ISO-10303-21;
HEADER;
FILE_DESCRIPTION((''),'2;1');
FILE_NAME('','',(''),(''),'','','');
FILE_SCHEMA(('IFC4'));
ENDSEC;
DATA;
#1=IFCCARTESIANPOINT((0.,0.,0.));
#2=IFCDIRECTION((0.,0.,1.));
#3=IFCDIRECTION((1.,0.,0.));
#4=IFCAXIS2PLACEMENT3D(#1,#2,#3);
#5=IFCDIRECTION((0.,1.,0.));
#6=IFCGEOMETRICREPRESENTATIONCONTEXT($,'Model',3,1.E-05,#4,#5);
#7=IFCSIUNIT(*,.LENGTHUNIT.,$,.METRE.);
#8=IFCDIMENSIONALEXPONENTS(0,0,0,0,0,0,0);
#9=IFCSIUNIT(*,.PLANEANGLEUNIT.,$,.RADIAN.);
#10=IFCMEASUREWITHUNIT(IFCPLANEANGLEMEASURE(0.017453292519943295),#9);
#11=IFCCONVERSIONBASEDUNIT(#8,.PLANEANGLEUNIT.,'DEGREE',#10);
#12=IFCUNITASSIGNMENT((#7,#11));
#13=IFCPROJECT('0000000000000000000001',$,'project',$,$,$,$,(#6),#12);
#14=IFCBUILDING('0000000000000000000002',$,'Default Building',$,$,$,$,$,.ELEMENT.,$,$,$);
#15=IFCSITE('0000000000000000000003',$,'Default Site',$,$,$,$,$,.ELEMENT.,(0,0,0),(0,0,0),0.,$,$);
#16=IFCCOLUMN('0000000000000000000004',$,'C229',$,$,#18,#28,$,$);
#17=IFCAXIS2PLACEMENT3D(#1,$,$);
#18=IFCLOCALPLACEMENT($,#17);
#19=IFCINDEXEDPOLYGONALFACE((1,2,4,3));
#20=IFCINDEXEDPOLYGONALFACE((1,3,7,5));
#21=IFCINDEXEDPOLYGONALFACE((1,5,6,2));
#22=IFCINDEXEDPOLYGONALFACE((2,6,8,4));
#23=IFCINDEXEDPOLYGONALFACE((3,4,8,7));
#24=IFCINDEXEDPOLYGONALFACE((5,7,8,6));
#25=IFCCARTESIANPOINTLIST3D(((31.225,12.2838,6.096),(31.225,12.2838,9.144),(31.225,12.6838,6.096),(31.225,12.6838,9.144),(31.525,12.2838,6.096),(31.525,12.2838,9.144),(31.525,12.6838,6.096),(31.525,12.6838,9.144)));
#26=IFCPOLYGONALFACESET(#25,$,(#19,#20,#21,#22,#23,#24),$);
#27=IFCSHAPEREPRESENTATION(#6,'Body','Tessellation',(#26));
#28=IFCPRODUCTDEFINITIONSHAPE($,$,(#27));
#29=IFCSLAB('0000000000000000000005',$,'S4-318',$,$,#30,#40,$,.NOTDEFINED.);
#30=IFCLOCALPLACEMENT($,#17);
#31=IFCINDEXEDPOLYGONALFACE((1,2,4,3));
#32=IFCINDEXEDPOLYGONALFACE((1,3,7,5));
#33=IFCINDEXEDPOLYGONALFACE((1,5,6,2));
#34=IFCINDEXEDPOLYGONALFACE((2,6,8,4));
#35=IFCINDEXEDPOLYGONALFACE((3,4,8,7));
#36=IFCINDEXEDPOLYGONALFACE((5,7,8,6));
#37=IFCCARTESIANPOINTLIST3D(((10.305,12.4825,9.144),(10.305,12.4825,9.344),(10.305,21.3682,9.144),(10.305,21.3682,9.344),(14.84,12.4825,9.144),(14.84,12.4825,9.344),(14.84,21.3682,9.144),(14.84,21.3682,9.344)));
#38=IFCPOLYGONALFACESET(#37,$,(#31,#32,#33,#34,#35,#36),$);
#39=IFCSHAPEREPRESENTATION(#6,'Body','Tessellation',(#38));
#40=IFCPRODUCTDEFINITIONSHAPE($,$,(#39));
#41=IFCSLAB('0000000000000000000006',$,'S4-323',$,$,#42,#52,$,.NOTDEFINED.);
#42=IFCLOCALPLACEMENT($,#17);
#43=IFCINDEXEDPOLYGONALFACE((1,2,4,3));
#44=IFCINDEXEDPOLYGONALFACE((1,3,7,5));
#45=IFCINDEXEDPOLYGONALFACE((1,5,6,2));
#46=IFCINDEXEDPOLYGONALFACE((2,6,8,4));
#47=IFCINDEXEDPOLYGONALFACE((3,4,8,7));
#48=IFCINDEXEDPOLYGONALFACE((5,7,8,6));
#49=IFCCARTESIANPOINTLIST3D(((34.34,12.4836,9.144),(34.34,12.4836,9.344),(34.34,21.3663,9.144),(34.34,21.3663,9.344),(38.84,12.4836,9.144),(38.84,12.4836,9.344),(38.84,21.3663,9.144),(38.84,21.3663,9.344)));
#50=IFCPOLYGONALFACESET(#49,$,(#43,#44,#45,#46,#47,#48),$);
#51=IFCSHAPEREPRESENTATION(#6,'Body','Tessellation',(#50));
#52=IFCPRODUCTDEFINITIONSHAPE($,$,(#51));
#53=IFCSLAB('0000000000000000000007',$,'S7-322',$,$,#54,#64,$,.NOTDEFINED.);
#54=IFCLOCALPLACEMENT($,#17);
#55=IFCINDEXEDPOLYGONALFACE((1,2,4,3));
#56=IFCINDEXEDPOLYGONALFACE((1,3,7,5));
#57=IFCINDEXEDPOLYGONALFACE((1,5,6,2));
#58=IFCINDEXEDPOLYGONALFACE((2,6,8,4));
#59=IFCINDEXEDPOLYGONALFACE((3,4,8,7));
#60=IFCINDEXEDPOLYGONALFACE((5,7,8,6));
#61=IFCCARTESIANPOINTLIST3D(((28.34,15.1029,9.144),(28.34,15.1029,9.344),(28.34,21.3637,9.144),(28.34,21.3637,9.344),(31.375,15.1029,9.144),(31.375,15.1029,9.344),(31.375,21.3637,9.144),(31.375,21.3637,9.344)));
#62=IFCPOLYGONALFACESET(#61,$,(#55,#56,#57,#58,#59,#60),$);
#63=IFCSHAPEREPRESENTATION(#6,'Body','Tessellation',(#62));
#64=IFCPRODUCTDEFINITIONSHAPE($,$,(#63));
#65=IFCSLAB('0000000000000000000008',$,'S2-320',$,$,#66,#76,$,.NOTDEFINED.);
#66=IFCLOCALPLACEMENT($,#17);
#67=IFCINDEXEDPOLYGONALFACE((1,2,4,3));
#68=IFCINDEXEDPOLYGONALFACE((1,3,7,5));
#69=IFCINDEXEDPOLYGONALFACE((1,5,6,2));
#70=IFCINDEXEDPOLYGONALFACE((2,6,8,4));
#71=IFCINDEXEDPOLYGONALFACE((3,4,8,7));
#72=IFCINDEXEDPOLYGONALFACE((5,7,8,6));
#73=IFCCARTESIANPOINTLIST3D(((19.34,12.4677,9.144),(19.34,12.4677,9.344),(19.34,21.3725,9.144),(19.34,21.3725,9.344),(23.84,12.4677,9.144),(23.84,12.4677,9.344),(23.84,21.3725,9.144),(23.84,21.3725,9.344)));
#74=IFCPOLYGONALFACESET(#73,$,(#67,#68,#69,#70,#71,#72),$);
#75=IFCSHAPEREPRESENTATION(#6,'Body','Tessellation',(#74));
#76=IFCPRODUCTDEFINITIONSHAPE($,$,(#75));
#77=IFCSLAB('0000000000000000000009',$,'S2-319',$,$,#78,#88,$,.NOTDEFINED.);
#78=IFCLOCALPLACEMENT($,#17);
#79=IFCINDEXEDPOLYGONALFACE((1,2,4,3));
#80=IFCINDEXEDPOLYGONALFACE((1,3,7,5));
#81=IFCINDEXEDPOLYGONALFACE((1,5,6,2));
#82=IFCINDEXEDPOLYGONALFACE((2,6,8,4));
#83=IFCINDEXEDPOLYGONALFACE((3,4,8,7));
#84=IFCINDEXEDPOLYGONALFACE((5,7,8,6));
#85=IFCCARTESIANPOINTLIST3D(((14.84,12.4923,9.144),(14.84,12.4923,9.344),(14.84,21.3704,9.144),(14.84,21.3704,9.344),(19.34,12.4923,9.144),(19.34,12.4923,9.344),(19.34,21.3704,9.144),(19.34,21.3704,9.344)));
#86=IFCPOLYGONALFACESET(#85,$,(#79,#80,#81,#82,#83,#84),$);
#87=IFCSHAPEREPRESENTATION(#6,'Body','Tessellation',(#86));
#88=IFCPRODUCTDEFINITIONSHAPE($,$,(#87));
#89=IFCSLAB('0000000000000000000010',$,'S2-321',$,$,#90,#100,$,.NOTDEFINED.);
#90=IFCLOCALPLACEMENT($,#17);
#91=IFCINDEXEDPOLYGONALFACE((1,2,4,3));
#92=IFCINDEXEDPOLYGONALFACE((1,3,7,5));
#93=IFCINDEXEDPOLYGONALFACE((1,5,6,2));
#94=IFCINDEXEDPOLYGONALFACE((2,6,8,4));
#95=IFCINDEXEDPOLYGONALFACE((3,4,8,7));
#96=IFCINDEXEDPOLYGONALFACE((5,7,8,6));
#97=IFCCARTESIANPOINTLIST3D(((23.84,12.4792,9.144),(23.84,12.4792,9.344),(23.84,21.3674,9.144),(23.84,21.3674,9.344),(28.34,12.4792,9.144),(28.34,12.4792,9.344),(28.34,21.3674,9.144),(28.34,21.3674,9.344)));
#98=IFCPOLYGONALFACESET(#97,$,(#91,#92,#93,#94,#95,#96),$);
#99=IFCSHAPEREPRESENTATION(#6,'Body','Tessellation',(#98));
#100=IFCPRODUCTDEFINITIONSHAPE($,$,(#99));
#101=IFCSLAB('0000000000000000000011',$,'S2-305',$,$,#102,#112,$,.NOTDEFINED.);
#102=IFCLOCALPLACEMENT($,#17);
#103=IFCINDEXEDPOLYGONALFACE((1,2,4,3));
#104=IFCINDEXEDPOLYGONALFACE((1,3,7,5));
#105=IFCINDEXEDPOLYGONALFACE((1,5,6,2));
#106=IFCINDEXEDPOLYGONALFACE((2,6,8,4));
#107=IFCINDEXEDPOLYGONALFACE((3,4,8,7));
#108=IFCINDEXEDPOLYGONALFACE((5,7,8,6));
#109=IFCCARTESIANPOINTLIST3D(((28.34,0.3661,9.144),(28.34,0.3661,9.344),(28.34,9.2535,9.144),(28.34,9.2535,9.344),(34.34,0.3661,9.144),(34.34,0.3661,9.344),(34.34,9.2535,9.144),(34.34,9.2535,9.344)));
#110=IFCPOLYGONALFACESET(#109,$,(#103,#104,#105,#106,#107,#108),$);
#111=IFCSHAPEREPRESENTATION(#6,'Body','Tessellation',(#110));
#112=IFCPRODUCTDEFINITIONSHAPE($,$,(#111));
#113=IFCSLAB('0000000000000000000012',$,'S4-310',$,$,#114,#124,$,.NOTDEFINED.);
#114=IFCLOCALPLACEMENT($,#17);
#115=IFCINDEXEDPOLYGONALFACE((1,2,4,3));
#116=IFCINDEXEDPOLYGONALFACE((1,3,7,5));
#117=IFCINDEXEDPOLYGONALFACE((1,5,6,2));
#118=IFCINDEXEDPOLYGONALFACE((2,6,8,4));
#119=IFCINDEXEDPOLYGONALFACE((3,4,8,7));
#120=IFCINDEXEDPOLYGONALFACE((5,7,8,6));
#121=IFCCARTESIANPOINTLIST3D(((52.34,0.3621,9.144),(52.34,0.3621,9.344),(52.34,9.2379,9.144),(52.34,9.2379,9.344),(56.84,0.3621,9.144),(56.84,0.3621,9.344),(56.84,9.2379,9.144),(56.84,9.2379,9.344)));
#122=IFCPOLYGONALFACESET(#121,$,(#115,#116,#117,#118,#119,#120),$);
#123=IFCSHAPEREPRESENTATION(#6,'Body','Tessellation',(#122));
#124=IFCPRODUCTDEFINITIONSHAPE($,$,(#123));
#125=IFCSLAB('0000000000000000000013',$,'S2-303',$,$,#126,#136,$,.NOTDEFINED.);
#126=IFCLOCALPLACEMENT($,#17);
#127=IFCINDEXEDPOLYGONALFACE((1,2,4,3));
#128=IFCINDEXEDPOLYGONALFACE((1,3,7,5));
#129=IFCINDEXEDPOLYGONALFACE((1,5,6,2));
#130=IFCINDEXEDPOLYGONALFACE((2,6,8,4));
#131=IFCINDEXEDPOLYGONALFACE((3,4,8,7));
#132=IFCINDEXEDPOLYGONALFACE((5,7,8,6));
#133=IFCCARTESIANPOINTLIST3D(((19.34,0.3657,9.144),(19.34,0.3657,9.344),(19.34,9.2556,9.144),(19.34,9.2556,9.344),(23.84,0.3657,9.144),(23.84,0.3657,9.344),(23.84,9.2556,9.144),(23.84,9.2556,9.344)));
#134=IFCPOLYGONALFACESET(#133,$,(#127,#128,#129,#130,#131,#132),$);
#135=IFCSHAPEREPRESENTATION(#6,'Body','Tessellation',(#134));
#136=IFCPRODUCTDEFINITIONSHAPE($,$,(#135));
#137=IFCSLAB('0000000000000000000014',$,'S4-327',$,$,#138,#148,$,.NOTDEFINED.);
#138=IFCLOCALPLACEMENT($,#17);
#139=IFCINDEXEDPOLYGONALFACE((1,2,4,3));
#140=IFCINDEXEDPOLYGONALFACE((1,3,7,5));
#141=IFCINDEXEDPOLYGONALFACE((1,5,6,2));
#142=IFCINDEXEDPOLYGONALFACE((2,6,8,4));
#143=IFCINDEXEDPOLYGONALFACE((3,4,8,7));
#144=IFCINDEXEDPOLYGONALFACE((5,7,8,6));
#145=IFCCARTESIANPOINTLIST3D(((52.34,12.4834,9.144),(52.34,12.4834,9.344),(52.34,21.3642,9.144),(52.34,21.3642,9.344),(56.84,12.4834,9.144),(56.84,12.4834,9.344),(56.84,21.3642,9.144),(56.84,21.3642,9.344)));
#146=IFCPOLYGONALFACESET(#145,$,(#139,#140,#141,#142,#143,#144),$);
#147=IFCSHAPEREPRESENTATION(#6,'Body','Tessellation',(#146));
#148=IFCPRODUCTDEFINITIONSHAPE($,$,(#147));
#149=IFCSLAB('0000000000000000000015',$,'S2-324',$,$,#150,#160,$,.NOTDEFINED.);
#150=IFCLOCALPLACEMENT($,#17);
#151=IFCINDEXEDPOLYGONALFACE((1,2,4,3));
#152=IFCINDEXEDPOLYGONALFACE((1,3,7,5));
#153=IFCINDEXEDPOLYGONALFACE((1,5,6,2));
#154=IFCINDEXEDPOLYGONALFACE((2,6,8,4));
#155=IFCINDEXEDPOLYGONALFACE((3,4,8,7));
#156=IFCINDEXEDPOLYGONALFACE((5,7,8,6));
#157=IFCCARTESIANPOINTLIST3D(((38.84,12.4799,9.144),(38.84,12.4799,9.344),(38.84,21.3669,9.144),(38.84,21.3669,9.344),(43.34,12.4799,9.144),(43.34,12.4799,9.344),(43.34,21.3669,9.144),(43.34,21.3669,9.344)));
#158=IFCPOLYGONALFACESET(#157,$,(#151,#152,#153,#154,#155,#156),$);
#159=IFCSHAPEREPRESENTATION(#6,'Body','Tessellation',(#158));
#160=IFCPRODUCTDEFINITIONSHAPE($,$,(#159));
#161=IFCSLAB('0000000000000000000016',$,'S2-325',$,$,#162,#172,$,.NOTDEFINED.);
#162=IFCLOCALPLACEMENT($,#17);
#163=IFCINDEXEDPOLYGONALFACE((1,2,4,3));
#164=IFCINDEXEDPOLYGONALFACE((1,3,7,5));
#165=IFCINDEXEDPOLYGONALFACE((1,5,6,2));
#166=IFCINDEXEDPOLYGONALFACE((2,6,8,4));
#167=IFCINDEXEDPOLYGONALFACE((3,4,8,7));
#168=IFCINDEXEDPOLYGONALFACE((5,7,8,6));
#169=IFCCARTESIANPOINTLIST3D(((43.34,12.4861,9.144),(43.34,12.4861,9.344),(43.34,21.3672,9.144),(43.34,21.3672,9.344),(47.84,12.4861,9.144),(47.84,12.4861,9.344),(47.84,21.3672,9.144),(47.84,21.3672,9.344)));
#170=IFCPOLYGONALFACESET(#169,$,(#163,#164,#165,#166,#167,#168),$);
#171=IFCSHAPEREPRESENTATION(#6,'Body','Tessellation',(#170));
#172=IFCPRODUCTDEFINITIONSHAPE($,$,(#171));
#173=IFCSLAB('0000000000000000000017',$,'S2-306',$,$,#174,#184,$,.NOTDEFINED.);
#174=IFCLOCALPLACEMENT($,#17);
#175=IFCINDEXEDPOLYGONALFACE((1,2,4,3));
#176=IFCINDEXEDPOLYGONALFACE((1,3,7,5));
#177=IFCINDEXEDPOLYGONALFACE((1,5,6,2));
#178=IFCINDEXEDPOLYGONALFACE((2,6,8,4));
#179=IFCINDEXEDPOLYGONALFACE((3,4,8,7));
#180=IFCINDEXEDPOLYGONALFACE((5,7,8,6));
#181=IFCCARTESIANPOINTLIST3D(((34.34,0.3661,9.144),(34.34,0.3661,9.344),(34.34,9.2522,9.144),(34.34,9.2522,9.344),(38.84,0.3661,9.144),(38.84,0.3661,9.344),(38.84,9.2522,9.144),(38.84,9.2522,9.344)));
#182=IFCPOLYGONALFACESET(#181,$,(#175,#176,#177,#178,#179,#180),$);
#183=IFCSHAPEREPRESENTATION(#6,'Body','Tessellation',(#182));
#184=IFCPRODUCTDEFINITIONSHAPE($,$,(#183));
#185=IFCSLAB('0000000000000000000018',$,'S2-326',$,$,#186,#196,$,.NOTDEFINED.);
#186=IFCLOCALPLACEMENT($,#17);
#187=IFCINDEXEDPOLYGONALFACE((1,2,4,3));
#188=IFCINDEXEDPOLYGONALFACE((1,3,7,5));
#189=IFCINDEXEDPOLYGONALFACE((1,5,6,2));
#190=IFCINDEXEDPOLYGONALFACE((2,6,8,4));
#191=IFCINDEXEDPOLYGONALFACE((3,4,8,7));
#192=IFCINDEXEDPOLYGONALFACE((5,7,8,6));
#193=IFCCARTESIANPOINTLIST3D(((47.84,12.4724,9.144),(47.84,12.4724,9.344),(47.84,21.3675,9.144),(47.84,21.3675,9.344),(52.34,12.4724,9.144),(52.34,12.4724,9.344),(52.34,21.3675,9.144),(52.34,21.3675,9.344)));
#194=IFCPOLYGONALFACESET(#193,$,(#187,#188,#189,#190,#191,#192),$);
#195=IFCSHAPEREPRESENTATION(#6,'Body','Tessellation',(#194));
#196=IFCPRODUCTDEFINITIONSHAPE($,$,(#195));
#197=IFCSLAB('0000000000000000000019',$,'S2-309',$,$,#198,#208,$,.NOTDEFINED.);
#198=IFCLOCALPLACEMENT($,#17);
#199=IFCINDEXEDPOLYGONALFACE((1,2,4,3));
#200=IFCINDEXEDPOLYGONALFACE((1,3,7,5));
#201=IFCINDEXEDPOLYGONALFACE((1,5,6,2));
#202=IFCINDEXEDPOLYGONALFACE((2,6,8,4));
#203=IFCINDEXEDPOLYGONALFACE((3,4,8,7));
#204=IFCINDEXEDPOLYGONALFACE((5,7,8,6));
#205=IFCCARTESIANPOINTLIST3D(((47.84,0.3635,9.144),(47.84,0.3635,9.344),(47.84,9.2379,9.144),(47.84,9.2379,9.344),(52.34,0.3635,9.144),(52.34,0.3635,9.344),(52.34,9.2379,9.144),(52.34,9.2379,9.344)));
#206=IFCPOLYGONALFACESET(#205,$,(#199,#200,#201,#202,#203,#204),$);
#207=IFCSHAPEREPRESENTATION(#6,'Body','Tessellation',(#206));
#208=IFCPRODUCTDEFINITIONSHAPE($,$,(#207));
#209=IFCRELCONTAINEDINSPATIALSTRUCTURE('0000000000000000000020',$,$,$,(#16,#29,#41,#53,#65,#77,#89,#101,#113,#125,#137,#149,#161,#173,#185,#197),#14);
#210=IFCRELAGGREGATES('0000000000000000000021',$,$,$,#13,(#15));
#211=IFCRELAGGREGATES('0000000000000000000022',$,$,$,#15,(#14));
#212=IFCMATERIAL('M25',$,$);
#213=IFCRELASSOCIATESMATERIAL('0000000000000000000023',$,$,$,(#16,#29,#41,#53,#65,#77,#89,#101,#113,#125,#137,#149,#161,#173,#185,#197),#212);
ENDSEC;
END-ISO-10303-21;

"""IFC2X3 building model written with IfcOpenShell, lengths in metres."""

from ifc_helpers import new_model, entity, si_unit, converted_unit, direction, frame, frame_2d, origin_with_axes, place, context, project, spatial, rectangle, extrude, material, element, save


model = new_model("IFC2X3")

# Units and contexts
model_context = context("Model", 3, precision=1e-05, world=origin_with_axes(), true_north=direction((0.0, 1.0, 0.0)))
ifc_project = project(units=[si_unit("LENGTHUNIT", "METRE"), converted_unit("PLANEANGLEUNIT", "DEGREE", entity("IfcPlaneAngleMeasure", 0.017453292519943295), si_unit("PLANEANGLEUNIT", "RADIAN"), dimensions=[0, 0, 0, 0, 0, 0, 0])], contexts=[model_context])

# Site, building
site = spatial("IfcSite", under=ifc_project, Name="Default Site", CompositionType="ELEMENT", RefLatitude=(0, 0, 0), RefLongitude=(0, 0, 0), RefElevation=0.0)
building = spatial("IfcBuilding", under=site, Name="Default Building", CompositionType="ELEMENT")

# Column
ifc_material = material(Name="M25")
placement = place(None, origin_with_axes())
element("IfcColumn", 1, at=placement, inside=building, material=ifc_material, Name="C229", context=model_context, shape_type="SweptSolid", body=[
    extrude(rectangle(XDim=0.3, YDim=0.4, at=frame_2d((0.0, 0.0), x_axis=(1.0, 0.0, 0.0))), frame((31.375, 12.4838, 6.096), z_axis=(0.0, 0.0, 1.0), x_axis=(1.0, 0.0, 0.0)), (0.0, 0.0, 1.0), 3.048),
])

# Slabs
element("IfcSlab", 2, at=placement, inside=building, material=ifc_material, Name="S4-318", PredefinedType="NOTDEFINED", context=model_context, shape_type="SweptSolid", body=[
    extrude(rectangle(XDim=4.535, YDim=8.8857, at=frame_2d((0.0, 0.0), x_axis=(1.0, 0.0, 0.0))), frame((12.5725, 16.9253, 9.144), z_axis=(0.0, 0.0, 1.0), x_axis=(1.0, 0.0, 0.0)), (0.0, 0.0, 1.0), 0.2),
])
element("IfcSlab", 3, at=placement, inside=building, material=ifc_material, Name="S4-323", PredefinedType="NOTDEFINED", context=model_context, shape_type="SweptSolid", body=[
    extrude(rectangle(XDim=4.5, YDim=8.8827, at=frame_2d((0.0, 0.0), x_axis=(1.0, 0.0, 0.0))), frame((36.59, 16.925, 9.144), z_axis=(0.0, 0.0, 1.0), x_axis=(1.0, 0.0, 0.0)), (0.0, 0.0, 1.0), 0.2),
])
element("IfcSlab", 4, at=placement, inside=building, material=ifc_material, Name="S7-322", PredefinedType="NOTDEFINED", context=model_context, shape_type="SweptSolid", body=[
    extrude(rectangle(XDim=3.035, YDim=6.2608, at=frame_2d((0.0, 0.0), x_axis=(1.0, 0.0, 0.0))), frame((29.8575, 18.2333, 9.144), z_axis=(0.0, 0.0, 1.0), x_axis=(1.0, 0.0, 0.0)), (0.0, 0.0, 1.0), 0.2),
])
element("IfcSlab", 5, at=placement, inside=building, material=ifc_material, Name="S2-320", PredefinedType="NOTDEFINED", context=model_context, shape_type="SweptSolid", body=[
    extrude(rectangle(XDim=4.5, YDim=8.9048, at=frame_2d((0.0, 0.0), x_axis=(1.0, 0.0, 0.0))), frame((21.59, 16.9201, 9.144), z_axis=(0.0, 0.0, 1.0), x_axis=(1.0, 0.0, 0.0)), (0.0, 0.0, 1.0), 0.2),
])
element("IfcSlab", 6, at=placement, inside=building, material=ifc_material, Name="S2-319", PredefinedType="NOTDEFINED", context=model_context, shape_type="SweptSolid", body=[
    extrude(rectangle(XDim=4.5, YDim=8.8781, at=frame_2d((0.0, 0.0), x_axis=(1.0, 0.0, 0.0))), frame((17.09, 16.9313, 9.144), z_axis=(0.0, 0.0, 1.0), x_axis=(1.0, 0.0, 0.0)), (0.0, 0.0, 1.0), 0.2),
])
element("IfcSlab", 7, at=placement, inside=building, material=ifc_material, Name="S2-321", PredefinedType="NOTDEFINED", context=model_context, shape_type="SweptSolid", body=[
    extrude(rectangle(XDim=4.5, YDim=8.8882, at=frame_2d((0.0, 0.0), x_axis=(1.0, 0.0, 0.0))), frame((26.09, 16.9233, 9.144), z_axis=(0.0, 0.0, 1.0), x_axis=(1.0, 0.0, 0.0)), (0.0, 0.0, 1.0), 0.2),
])
element("IfcSlab", 8, at=placement, inside=building, material=ifc_material, Name="S2-305", PredefinedType="NOTDEFINED", context=model_context, shape_type="SweptSolid", body=[
    extrude(rectangle(XDim=6.0, YDim=8.8874, at=frame_2d((0.0, 0.0), x_axis=(1.0, 0.0, 0.0))), frame((31.34, 4.8098, 9.144), z_axis=(0.0, 0.0, 1.0), x_axis=(1.0, 0.0, 0.0)), (0.0, 0.0, 1.0), 0.2),
])
element("IfcSlab", 9, at=placement, inside=building, material=ifc_material, Name="S4-310", PredefinedType="NOTDEFINED", context=model_context, shape_type="SweptSolid", body=[
    extrude(rectangle(XDim=4.5, YDim=8.8758, at=frame_2d((0.0, 0.0), x_axis=(1.0, 0.0, 0.0))), frame((54.59, 4.8, 9.144), z_axis=(0.0, 0.0, 1.0), x_axis=(1.0, 0.0, 0.0)), (0.0, 0.0, 1.0), 0.2),
])
element("IfcSlab", 10, at=placement, inside=building, material=ifc_material, Name="S2-303", PredefinedType="NOTDEFINED", context=model_context, shape_type="SweptSolid", body=[
    extrude(rectangle(XDim=4.5, YDim=8.89, at=frame_2d((0.0, 0.0), x_axis=(1.0, 0.0, 0.0))), frame((21.59, 4.8106, 9.144), z_axis=(0.0, 0.0, 1.0), x_axis=(1.0, 0.0, 0.0)), (0.0, 0.0, 1.0), 0.2),
])
element("IfcSlab", 11, at=placement, inside=building, material=ifc_material, Name="S4-327", PredefinedType="NOTDEFINED", context=model_context, shape_type="SweptSolid", body=[
    extrude(rectangle(XDim=4.5, YDim=8.8807, at=frame_2d((0.0, 0.0), x_axis=(1.0, 0.0, 0.0))), frame((54.59, 16.9238, 9.144), z_axis=(0.0, 0.0, 1.0), x_axis=(1.0, 0.0, 0.0)), (0.0, 0.0, 1.0), 0.2),
])
element("IfcSlab", 12, at=placement, inside=building, material=ifc_material, Name="S2-324", PredefinedType="NOTDEFINED", context=model_context, shape_type="SweptSolid", body=[
    extrude(rectangle(XDim=4.5, YDim=8.8871, at=frame_2d((0.0, 0.0), x_axis=(1.0, 0.0, 0.0))), frame((41.09, 16.9234, 9.144), z_axis=(0.0, 0.0, 1.0), x_axis=(1.0, 0.0, 0.0)), (0.0, 0.0, 1.0), 0.2),
])
element("IfcSlab", 13, at=placement, inside=building, material=ifc_material, Name="S2-325", PredefinedType="NOTDEFINED", context=model_context, shape_type="SweptSolid", body=[
    extrude(rectangle(XDim=4.5, YDim=8.8811, at=frame_2d((0.0, 0.0), x_axis=(1.0, 0.0, 0.0))), frame((45.59, 16.9266, 9.144), z_axis=(0.0, 0.0, 1.0), x_axis=(1.0, 0.0, 0.0)), (0.0, 0.0, 1.0), 0.2),
])
element("IfcSlab", 14, at=placement, inside=building, material=ifc_material, Name="S2-306", PredefinedType="NOTDEFINED", context=model_context, shape_type="SweptSolid", body=[
    extrude(rectangle(XDim=4.5, YDim=8.8861, at=frame_2d((0.0, 0.0), x_axis=(1.0, 0.0, 0.0))), frame((36.59, 4.8092, 9.144), z_axis=(0.0, 0.0, 1.0), x_axis=(1.0, 0.0, 0.0)), (0.0, 0.0, 1.0), 0.2),
])
element("IfcSlab", 15, at=placement, inside=building, material=ifc_material, Name="S2-326", PredefinedType="NOTDEFINED", context=model_context, shape_type="SweptSolid", body=[
    extrude(rectangle(XDim=4.5, YDim=8.8951, at=frame_2d((0.0, 0.0), x_axis=(1.0, 0.0, 0.0))), frame((50.09, 16.9199, 9.144), z_axis=(0.0, 0.0, 1.0), x_axis=(1.0, 0.0, 0.0)), (0.0, 0.0, 1.0), 0.2),
])
element("IfcSlab", 16, at=placement, inside=building, material=ifc_material, Name="S2-309", PredefinedType="NOTDEFINED", context=model_context, shape_type="SweptSolid", body=[
    extrude(rectangle(XDim=4.5, YDim=8.8744, at=frame_2d((0.0, 0.0), x_axis=(1.0, 0.0, 0.0))), frame((50.09, 4.8007, 9.144), z_axis=(0.0, 0.0, 1.0), x_axis=(1.0, 0.0, 0.0)), (0.0, 0.0, 1.0), 0.2),
])

save(model, "model.ifc")
